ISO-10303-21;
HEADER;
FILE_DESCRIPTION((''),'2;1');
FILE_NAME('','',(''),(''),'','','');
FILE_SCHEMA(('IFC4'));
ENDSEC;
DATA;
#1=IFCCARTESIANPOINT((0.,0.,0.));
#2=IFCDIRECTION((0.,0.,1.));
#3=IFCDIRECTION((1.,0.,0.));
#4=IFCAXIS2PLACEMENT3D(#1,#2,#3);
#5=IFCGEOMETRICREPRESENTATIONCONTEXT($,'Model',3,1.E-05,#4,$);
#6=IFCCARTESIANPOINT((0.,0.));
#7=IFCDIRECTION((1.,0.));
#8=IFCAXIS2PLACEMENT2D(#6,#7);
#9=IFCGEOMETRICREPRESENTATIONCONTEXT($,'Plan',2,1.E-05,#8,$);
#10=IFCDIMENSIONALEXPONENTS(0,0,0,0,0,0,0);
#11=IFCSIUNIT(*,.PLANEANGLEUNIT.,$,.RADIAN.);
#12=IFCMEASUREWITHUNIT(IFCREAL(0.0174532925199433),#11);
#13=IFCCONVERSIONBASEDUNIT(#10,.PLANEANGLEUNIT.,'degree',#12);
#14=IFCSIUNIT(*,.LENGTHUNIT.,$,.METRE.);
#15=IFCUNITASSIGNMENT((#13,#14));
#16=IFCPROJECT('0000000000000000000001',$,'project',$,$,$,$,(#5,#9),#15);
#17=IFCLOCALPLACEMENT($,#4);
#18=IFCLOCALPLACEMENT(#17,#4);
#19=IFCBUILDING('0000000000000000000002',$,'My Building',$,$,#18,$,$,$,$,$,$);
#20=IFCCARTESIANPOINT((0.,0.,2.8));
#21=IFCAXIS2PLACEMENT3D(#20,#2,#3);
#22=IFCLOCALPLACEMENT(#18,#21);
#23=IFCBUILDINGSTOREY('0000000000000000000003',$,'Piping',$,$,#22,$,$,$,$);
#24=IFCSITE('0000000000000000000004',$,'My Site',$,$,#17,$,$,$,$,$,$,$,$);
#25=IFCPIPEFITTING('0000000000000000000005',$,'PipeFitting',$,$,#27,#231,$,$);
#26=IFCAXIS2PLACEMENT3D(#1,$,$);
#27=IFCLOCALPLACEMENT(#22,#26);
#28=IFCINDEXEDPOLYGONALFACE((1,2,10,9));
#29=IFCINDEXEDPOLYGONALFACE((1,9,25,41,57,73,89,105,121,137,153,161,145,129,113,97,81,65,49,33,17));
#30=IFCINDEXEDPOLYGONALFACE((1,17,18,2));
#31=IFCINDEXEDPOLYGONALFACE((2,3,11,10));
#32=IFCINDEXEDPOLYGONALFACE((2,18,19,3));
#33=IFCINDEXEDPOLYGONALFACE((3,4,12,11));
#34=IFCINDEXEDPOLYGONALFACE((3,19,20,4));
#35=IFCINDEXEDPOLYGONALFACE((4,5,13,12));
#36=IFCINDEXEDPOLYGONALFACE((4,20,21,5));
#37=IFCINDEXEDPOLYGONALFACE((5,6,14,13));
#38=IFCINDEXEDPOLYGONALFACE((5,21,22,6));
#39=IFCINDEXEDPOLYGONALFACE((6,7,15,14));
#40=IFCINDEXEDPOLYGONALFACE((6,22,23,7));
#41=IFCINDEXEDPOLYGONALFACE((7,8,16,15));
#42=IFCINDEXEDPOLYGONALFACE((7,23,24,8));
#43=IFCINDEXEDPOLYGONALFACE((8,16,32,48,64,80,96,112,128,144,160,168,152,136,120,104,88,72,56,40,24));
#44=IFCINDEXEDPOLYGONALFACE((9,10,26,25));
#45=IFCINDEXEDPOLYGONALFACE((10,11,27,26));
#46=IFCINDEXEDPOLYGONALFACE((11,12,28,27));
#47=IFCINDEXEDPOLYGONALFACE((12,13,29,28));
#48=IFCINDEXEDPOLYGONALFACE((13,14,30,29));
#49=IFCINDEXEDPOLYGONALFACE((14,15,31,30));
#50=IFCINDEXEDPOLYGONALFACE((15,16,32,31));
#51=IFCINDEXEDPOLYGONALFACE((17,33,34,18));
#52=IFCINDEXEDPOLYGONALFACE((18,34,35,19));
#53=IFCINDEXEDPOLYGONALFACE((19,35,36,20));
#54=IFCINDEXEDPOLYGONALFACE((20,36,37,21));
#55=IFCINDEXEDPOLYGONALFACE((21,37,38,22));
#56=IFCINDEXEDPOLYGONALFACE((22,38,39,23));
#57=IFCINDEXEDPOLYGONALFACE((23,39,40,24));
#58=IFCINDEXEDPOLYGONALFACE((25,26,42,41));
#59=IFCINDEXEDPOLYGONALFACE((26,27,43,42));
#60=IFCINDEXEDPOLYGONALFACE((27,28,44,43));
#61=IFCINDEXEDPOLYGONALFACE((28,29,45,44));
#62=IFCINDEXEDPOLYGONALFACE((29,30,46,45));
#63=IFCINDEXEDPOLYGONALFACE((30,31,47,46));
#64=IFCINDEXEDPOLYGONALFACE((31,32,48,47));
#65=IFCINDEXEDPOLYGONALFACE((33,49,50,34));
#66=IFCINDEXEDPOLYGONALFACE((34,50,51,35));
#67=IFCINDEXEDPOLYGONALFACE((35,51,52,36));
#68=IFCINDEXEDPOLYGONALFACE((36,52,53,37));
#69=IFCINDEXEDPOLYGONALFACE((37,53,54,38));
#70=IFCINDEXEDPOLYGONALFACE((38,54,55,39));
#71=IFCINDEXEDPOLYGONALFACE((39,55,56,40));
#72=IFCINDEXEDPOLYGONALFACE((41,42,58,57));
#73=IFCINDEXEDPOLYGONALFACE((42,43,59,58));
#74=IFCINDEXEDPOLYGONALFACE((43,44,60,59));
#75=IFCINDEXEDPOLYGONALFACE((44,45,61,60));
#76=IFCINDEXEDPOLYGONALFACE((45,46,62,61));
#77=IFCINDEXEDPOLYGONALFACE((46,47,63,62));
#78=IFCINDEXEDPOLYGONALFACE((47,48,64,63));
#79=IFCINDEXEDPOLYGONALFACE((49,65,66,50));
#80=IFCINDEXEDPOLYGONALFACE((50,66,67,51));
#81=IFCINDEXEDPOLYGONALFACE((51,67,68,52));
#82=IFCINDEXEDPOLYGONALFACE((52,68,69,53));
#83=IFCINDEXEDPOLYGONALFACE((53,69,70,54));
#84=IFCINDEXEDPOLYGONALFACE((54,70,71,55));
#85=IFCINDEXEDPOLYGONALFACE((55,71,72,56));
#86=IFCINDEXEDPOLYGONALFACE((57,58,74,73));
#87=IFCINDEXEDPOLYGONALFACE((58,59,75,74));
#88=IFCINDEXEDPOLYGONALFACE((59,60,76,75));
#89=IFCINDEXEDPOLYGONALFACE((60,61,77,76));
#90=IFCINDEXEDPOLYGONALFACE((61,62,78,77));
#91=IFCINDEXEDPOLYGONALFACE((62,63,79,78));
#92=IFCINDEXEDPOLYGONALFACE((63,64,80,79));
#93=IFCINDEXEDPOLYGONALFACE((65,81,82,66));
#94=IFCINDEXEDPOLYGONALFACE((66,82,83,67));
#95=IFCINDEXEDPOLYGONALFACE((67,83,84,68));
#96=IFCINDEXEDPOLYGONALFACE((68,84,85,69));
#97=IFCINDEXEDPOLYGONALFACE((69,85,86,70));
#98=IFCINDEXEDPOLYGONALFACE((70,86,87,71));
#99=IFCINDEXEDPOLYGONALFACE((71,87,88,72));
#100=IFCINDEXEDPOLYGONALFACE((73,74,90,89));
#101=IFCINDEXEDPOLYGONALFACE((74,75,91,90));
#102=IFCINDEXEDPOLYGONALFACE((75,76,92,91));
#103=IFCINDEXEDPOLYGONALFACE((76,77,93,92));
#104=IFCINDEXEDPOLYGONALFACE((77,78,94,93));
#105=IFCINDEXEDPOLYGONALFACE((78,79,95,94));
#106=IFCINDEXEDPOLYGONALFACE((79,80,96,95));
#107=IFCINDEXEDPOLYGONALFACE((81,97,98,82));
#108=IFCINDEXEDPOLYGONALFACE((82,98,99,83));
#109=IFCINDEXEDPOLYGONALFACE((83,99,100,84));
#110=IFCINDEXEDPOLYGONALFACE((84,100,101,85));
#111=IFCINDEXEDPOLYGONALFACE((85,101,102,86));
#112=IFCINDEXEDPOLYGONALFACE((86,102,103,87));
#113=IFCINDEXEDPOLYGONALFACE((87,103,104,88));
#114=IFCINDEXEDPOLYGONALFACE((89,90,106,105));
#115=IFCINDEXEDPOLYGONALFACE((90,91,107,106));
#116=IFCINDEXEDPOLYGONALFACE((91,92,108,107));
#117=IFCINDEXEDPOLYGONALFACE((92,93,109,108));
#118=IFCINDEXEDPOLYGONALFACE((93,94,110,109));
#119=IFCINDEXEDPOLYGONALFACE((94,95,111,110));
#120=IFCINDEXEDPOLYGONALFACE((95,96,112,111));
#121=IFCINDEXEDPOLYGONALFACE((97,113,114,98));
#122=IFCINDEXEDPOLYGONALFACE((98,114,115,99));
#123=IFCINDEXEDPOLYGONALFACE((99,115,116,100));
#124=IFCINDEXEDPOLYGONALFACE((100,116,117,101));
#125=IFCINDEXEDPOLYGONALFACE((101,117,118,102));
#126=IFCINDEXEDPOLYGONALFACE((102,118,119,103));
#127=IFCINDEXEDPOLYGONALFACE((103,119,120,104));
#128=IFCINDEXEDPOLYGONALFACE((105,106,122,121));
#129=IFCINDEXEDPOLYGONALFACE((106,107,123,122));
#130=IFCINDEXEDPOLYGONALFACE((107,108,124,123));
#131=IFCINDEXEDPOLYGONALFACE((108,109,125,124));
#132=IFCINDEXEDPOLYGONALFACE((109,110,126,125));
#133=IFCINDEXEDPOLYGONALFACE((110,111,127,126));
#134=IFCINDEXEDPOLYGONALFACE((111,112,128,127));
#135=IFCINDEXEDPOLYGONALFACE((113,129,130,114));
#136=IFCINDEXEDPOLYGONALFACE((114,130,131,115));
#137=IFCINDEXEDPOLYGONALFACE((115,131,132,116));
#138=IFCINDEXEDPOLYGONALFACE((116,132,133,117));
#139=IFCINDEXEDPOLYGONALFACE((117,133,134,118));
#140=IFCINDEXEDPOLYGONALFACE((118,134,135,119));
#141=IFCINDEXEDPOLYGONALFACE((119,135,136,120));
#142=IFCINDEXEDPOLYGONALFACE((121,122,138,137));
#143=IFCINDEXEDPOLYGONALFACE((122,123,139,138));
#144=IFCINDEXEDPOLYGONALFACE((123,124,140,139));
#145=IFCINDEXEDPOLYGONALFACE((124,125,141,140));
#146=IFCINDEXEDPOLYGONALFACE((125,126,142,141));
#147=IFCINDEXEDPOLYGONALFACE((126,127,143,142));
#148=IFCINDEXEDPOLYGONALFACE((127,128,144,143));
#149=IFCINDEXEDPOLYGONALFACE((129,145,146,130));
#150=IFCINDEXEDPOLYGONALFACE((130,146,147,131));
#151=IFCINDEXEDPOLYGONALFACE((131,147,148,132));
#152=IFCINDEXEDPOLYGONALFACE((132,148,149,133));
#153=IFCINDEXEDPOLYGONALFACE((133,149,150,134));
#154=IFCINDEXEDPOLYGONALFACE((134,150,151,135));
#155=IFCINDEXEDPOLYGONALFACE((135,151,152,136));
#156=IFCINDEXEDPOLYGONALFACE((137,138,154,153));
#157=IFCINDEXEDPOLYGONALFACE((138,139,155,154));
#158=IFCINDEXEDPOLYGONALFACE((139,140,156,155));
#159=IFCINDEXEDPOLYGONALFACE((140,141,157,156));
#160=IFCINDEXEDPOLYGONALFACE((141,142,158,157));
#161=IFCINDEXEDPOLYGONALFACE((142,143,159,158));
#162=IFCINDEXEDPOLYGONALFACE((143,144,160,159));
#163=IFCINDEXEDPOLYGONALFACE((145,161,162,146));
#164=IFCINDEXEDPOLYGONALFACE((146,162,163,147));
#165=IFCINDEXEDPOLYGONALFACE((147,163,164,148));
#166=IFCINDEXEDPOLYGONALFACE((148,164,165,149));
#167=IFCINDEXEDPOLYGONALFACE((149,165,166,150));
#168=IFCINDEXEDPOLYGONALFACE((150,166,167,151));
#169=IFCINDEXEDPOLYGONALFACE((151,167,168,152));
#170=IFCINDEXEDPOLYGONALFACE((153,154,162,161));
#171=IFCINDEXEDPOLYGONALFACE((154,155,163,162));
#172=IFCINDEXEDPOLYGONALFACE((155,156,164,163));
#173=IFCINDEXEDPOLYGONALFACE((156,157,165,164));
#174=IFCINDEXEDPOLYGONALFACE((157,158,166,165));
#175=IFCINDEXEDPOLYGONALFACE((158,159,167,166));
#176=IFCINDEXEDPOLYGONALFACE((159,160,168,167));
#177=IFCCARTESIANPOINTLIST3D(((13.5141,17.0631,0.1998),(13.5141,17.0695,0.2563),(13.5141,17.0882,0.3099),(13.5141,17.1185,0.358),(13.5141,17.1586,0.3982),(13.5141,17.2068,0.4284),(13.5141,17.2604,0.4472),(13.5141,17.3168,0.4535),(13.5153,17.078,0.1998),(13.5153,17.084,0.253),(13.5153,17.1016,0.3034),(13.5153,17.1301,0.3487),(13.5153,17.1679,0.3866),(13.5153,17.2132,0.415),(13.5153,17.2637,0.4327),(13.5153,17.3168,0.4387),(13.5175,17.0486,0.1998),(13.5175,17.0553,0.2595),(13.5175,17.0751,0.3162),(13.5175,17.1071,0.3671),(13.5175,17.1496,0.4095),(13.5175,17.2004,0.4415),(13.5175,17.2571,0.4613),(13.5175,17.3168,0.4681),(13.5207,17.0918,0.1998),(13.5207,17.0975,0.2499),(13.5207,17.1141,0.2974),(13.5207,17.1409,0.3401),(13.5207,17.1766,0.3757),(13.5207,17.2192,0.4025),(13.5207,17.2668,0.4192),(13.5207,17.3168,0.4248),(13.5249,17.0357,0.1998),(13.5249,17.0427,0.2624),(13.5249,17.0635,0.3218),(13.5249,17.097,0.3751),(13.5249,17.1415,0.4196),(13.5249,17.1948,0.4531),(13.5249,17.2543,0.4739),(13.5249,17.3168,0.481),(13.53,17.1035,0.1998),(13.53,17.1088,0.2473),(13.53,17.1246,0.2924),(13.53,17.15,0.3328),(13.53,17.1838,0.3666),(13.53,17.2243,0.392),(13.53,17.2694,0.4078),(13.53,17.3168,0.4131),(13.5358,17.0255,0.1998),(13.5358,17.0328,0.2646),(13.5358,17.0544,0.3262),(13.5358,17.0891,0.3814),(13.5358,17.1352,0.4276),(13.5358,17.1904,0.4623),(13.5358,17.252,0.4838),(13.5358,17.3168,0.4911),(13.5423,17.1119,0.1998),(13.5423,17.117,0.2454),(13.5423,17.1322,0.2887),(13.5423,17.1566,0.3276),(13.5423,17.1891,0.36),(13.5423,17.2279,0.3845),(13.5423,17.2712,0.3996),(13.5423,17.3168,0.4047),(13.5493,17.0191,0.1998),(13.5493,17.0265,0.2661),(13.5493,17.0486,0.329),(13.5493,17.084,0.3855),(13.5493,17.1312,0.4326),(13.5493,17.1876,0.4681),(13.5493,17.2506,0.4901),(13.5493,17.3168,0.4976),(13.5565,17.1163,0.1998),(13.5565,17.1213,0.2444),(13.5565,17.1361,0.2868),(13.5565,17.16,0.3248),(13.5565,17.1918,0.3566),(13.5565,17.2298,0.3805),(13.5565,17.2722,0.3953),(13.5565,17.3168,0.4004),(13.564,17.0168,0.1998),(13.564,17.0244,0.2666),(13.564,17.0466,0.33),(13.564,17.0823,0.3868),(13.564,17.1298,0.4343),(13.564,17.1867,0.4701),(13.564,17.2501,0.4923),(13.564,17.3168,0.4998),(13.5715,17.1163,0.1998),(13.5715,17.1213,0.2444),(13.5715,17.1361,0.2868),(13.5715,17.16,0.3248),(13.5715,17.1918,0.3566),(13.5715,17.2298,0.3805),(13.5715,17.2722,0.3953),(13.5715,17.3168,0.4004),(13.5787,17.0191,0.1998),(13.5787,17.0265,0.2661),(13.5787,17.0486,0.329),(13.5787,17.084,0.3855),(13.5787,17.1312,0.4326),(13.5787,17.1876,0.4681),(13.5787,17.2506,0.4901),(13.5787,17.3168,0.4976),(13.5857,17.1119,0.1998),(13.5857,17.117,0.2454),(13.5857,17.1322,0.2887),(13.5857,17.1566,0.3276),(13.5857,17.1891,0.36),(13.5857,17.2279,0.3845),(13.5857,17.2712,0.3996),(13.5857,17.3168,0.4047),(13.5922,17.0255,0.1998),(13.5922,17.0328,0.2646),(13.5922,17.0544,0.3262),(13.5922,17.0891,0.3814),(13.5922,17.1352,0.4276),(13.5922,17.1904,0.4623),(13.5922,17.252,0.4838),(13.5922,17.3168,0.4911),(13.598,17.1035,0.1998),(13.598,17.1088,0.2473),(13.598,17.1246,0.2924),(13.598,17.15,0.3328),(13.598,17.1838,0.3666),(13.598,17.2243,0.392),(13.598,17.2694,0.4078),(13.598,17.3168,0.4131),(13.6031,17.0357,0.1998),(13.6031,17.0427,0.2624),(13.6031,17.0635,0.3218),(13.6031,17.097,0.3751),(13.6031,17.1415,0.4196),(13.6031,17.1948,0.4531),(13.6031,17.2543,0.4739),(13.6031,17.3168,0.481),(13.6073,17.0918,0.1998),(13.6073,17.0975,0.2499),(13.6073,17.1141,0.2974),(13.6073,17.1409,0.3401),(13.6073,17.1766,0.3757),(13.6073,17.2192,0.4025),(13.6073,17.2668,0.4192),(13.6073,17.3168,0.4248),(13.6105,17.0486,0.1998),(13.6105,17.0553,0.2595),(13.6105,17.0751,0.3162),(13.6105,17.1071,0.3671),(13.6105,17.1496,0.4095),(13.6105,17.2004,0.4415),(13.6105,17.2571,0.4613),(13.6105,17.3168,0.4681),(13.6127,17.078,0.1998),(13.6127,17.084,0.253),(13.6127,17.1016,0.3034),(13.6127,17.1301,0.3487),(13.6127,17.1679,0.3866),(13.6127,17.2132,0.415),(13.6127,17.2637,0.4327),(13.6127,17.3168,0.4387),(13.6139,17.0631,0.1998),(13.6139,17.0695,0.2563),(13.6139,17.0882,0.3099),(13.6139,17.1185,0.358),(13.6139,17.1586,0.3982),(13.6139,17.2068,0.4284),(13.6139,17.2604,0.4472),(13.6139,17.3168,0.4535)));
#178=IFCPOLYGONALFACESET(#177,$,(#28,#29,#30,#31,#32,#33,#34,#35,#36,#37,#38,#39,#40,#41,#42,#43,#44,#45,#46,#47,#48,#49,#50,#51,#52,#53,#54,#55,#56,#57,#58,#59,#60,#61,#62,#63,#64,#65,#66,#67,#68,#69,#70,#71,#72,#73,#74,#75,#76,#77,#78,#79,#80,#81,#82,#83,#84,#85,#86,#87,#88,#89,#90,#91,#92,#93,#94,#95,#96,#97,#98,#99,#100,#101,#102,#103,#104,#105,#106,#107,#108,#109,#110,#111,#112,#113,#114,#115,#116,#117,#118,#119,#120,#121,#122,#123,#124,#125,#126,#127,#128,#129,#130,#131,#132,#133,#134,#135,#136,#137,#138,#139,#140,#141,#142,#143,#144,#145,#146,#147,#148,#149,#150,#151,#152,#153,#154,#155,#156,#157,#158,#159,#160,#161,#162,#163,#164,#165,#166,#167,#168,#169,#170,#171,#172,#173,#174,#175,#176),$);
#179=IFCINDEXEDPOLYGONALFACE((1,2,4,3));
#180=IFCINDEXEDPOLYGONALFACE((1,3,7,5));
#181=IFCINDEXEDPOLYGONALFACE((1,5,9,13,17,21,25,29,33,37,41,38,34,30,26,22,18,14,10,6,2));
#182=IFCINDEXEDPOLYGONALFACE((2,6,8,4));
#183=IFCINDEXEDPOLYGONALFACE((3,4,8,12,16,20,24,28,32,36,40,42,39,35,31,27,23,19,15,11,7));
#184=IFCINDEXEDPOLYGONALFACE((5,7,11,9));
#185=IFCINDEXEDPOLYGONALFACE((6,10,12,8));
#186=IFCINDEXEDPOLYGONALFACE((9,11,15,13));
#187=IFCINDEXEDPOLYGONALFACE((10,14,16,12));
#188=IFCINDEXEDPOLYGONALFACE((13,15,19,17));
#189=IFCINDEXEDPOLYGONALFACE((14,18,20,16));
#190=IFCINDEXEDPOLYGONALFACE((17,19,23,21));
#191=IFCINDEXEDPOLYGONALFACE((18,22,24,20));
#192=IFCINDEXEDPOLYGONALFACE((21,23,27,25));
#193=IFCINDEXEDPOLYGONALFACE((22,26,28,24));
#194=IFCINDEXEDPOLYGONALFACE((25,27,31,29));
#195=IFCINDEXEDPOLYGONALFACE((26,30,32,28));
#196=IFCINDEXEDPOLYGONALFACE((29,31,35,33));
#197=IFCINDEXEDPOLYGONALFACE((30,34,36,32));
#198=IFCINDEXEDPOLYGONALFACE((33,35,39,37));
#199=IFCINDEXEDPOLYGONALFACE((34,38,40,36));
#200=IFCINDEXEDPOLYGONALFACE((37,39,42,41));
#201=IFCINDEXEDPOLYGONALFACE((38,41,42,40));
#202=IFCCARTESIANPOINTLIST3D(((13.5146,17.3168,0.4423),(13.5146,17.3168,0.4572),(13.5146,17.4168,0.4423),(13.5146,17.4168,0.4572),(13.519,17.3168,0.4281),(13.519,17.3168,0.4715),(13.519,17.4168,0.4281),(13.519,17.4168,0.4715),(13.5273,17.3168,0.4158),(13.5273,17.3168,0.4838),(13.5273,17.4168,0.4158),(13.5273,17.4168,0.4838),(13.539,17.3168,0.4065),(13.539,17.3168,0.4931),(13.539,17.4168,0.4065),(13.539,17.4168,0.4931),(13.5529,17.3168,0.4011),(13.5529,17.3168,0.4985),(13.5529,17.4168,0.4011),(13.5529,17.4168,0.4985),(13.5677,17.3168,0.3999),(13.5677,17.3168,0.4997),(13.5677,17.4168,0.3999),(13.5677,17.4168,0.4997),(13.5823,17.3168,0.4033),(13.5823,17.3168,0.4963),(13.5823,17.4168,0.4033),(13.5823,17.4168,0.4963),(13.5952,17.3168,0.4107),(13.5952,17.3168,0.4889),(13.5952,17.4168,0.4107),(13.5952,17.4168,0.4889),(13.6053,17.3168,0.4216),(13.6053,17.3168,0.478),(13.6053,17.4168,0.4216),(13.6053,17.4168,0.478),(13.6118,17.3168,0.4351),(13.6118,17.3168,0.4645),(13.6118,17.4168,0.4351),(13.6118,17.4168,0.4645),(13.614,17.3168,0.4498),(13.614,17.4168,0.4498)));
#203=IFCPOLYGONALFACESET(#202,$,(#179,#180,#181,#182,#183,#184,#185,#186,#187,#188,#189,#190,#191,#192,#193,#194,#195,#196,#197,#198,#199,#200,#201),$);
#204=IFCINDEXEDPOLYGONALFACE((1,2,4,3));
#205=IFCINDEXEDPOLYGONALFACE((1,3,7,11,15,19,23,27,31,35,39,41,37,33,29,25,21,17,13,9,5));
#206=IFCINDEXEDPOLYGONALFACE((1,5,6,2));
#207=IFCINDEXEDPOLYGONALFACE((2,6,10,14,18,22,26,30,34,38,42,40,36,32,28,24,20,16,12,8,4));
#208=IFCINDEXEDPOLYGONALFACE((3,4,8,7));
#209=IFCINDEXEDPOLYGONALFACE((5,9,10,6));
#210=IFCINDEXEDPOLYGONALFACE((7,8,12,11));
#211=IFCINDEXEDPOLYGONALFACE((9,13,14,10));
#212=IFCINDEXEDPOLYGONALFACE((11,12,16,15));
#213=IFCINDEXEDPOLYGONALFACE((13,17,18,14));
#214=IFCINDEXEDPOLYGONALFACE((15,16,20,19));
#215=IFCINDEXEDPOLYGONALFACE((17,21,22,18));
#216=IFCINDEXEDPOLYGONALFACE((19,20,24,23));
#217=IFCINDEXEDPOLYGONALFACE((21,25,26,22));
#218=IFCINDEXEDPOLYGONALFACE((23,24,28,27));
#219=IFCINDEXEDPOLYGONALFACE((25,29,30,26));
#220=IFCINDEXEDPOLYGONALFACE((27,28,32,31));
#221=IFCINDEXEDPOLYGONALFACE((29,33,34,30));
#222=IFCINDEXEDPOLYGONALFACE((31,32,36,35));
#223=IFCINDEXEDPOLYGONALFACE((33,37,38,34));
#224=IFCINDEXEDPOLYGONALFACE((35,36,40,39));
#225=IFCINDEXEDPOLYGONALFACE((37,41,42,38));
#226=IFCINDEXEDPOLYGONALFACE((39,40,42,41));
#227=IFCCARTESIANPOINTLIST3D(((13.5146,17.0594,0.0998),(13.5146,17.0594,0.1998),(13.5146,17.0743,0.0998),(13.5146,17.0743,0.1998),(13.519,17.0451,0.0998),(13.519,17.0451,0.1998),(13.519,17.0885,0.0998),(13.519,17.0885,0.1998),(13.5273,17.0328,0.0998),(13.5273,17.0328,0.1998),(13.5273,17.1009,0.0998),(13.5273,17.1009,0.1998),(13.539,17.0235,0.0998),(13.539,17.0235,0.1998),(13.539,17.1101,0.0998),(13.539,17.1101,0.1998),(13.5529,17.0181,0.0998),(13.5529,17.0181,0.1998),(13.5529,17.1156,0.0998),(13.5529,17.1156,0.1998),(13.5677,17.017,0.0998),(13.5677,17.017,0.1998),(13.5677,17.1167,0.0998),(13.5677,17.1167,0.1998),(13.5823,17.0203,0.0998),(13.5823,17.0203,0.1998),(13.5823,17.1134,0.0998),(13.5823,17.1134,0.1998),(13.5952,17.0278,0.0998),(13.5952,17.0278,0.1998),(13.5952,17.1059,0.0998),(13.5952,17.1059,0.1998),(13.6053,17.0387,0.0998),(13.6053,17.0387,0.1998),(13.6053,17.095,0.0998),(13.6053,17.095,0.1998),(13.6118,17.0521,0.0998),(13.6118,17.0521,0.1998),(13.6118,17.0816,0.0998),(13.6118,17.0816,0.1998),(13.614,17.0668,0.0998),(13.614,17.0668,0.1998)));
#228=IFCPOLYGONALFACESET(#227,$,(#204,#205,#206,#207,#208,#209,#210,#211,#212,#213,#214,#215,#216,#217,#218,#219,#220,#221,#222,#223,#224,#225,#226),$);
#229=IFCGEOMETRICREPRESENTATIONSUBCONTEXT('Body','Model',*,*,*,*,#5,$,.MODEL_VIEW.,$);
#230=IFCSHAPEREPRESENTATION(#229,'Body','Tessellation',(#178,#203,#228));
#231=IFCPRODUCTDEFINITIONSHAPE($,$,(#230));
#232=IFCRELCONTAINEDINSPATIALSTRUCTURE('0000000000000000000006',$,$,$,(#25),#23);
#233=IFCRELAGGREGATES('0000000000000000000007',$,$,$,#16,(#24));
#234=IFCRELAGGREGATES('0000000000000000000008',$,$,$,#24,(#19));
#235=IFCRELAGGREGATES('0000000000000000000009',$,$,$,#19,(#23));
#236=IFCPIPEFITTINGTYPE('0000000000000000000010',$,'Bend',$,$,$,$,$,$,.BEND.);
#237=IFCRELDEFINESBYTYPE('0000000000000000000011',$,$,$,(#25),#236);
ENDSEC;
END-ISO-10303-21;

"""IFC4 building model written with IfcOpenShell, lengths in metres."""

from ifc_helpers import new_model, entity, si_unit, converted_unit, frame, origin_with_axes, origin_2d_with_axis, place, context, subcontext, project, spatial, circle, extrude, source, transform, mapped, type_object, type_shapes, element, save


model = new_model("IFC4")

# Units and contexts
model_context = context("Model", 3, precision=1e-05, world=origin_with_axes())
plan_context = context("Plan", 2, precision=1e-05, world=origin_2d_with_axis())
body_context = subcontext(model_context, "Body", "Model", "MODEL_VIEW")
ifc_project = project(units=[converted_unit("PLANEANGLEUNIT", "degree", entity("IfcReal", 0.0174532925199433), si_unit("PLANEANGLEUNIT", "RADIAN"), dimensions=[0, 0, 0, 0, 0, 0, 0]), si_unit("LENGTHUNIT", "METRE")], contexts=[model_context, plan_context])

# Site, building, storey
site_placement = place(None, origin_with_axes())
site = spatial("IfcSite", under=ifc_project, at=site_placement, Name="My Site")
building_placement = place(site_placement, origin_with_axes())
building = spatial("IfcBuilding", under=site, at=building_placement, Name="My Building")
storey_placement = place(building_placement, frame((0.0, 0.0, 2.8), z_axis=(0.0, 0.0, 1.0), x_axis=(1.0, 0.0, 0.0)))
storey = spatial("IfcBuildingStorey", under=building, at=storey_placement, Name="Piping")

# Pipe fitting
pipe_fitting_type_1 = type_object("IfcPipeFittingType", Name="Bend", PredefinedType="BEND")
shared_shape_1 = source(origin_with_axes(), body_context, "Body", "SolidModel", [
    entity("IfcSweptDiskSolid", entity("IfcIndexedPolyCurve", entity("IfcCartesianPointList3D", [[0.0, 0.0, 0.1], [0.0, -0.0732, 0.2768], [0.0, -0.25, 0.35]]), [entity("IfcArcIndex", [1, 2, 3])]), 0.05),
    extrude(circle(Radius=0.05), origin_with_axes(), (0.0, 0.0, 1.0), 0.1),
    extrude(circle(Radius=0.05), frame((0.0, -0.25, 0.35), z_axis=(0.0, -1.0, 0.0), x_axis=(1.0, 0.0, 0.0)), (0.0, 0.0, 1.0), 0.1),
])
type_shapes(pipe_fitting_type_1, [shared_shape_1])
for number, where, z_axis, x_axis, name in (
    (1, (13.564, 17.4168, 0.4498), (0.0, -1.0, 0.0), (1.0, 0.0, 0.0), "PipeFitting"),
):
    element("IfcPipeFitting", number, at=place(storey_placement, frame(where, z_axis=z_axis, x_axis=x_axis)), inside=storey, type_object=pipe_fitting_type_1, Name=name, context=body_context, shape_type="MappedRepresentation", body=[
        mapped(shared_shape_1, transform((0.0, 0.0, 0.0), x_axis=(1.0, 0.0, 0.0), y_axis=(0.0, 1.0, 0.0), z_axis=(0.0, 0.0, 1.0), scale=1.0)),
    ])

save(model, "model.ifc")
